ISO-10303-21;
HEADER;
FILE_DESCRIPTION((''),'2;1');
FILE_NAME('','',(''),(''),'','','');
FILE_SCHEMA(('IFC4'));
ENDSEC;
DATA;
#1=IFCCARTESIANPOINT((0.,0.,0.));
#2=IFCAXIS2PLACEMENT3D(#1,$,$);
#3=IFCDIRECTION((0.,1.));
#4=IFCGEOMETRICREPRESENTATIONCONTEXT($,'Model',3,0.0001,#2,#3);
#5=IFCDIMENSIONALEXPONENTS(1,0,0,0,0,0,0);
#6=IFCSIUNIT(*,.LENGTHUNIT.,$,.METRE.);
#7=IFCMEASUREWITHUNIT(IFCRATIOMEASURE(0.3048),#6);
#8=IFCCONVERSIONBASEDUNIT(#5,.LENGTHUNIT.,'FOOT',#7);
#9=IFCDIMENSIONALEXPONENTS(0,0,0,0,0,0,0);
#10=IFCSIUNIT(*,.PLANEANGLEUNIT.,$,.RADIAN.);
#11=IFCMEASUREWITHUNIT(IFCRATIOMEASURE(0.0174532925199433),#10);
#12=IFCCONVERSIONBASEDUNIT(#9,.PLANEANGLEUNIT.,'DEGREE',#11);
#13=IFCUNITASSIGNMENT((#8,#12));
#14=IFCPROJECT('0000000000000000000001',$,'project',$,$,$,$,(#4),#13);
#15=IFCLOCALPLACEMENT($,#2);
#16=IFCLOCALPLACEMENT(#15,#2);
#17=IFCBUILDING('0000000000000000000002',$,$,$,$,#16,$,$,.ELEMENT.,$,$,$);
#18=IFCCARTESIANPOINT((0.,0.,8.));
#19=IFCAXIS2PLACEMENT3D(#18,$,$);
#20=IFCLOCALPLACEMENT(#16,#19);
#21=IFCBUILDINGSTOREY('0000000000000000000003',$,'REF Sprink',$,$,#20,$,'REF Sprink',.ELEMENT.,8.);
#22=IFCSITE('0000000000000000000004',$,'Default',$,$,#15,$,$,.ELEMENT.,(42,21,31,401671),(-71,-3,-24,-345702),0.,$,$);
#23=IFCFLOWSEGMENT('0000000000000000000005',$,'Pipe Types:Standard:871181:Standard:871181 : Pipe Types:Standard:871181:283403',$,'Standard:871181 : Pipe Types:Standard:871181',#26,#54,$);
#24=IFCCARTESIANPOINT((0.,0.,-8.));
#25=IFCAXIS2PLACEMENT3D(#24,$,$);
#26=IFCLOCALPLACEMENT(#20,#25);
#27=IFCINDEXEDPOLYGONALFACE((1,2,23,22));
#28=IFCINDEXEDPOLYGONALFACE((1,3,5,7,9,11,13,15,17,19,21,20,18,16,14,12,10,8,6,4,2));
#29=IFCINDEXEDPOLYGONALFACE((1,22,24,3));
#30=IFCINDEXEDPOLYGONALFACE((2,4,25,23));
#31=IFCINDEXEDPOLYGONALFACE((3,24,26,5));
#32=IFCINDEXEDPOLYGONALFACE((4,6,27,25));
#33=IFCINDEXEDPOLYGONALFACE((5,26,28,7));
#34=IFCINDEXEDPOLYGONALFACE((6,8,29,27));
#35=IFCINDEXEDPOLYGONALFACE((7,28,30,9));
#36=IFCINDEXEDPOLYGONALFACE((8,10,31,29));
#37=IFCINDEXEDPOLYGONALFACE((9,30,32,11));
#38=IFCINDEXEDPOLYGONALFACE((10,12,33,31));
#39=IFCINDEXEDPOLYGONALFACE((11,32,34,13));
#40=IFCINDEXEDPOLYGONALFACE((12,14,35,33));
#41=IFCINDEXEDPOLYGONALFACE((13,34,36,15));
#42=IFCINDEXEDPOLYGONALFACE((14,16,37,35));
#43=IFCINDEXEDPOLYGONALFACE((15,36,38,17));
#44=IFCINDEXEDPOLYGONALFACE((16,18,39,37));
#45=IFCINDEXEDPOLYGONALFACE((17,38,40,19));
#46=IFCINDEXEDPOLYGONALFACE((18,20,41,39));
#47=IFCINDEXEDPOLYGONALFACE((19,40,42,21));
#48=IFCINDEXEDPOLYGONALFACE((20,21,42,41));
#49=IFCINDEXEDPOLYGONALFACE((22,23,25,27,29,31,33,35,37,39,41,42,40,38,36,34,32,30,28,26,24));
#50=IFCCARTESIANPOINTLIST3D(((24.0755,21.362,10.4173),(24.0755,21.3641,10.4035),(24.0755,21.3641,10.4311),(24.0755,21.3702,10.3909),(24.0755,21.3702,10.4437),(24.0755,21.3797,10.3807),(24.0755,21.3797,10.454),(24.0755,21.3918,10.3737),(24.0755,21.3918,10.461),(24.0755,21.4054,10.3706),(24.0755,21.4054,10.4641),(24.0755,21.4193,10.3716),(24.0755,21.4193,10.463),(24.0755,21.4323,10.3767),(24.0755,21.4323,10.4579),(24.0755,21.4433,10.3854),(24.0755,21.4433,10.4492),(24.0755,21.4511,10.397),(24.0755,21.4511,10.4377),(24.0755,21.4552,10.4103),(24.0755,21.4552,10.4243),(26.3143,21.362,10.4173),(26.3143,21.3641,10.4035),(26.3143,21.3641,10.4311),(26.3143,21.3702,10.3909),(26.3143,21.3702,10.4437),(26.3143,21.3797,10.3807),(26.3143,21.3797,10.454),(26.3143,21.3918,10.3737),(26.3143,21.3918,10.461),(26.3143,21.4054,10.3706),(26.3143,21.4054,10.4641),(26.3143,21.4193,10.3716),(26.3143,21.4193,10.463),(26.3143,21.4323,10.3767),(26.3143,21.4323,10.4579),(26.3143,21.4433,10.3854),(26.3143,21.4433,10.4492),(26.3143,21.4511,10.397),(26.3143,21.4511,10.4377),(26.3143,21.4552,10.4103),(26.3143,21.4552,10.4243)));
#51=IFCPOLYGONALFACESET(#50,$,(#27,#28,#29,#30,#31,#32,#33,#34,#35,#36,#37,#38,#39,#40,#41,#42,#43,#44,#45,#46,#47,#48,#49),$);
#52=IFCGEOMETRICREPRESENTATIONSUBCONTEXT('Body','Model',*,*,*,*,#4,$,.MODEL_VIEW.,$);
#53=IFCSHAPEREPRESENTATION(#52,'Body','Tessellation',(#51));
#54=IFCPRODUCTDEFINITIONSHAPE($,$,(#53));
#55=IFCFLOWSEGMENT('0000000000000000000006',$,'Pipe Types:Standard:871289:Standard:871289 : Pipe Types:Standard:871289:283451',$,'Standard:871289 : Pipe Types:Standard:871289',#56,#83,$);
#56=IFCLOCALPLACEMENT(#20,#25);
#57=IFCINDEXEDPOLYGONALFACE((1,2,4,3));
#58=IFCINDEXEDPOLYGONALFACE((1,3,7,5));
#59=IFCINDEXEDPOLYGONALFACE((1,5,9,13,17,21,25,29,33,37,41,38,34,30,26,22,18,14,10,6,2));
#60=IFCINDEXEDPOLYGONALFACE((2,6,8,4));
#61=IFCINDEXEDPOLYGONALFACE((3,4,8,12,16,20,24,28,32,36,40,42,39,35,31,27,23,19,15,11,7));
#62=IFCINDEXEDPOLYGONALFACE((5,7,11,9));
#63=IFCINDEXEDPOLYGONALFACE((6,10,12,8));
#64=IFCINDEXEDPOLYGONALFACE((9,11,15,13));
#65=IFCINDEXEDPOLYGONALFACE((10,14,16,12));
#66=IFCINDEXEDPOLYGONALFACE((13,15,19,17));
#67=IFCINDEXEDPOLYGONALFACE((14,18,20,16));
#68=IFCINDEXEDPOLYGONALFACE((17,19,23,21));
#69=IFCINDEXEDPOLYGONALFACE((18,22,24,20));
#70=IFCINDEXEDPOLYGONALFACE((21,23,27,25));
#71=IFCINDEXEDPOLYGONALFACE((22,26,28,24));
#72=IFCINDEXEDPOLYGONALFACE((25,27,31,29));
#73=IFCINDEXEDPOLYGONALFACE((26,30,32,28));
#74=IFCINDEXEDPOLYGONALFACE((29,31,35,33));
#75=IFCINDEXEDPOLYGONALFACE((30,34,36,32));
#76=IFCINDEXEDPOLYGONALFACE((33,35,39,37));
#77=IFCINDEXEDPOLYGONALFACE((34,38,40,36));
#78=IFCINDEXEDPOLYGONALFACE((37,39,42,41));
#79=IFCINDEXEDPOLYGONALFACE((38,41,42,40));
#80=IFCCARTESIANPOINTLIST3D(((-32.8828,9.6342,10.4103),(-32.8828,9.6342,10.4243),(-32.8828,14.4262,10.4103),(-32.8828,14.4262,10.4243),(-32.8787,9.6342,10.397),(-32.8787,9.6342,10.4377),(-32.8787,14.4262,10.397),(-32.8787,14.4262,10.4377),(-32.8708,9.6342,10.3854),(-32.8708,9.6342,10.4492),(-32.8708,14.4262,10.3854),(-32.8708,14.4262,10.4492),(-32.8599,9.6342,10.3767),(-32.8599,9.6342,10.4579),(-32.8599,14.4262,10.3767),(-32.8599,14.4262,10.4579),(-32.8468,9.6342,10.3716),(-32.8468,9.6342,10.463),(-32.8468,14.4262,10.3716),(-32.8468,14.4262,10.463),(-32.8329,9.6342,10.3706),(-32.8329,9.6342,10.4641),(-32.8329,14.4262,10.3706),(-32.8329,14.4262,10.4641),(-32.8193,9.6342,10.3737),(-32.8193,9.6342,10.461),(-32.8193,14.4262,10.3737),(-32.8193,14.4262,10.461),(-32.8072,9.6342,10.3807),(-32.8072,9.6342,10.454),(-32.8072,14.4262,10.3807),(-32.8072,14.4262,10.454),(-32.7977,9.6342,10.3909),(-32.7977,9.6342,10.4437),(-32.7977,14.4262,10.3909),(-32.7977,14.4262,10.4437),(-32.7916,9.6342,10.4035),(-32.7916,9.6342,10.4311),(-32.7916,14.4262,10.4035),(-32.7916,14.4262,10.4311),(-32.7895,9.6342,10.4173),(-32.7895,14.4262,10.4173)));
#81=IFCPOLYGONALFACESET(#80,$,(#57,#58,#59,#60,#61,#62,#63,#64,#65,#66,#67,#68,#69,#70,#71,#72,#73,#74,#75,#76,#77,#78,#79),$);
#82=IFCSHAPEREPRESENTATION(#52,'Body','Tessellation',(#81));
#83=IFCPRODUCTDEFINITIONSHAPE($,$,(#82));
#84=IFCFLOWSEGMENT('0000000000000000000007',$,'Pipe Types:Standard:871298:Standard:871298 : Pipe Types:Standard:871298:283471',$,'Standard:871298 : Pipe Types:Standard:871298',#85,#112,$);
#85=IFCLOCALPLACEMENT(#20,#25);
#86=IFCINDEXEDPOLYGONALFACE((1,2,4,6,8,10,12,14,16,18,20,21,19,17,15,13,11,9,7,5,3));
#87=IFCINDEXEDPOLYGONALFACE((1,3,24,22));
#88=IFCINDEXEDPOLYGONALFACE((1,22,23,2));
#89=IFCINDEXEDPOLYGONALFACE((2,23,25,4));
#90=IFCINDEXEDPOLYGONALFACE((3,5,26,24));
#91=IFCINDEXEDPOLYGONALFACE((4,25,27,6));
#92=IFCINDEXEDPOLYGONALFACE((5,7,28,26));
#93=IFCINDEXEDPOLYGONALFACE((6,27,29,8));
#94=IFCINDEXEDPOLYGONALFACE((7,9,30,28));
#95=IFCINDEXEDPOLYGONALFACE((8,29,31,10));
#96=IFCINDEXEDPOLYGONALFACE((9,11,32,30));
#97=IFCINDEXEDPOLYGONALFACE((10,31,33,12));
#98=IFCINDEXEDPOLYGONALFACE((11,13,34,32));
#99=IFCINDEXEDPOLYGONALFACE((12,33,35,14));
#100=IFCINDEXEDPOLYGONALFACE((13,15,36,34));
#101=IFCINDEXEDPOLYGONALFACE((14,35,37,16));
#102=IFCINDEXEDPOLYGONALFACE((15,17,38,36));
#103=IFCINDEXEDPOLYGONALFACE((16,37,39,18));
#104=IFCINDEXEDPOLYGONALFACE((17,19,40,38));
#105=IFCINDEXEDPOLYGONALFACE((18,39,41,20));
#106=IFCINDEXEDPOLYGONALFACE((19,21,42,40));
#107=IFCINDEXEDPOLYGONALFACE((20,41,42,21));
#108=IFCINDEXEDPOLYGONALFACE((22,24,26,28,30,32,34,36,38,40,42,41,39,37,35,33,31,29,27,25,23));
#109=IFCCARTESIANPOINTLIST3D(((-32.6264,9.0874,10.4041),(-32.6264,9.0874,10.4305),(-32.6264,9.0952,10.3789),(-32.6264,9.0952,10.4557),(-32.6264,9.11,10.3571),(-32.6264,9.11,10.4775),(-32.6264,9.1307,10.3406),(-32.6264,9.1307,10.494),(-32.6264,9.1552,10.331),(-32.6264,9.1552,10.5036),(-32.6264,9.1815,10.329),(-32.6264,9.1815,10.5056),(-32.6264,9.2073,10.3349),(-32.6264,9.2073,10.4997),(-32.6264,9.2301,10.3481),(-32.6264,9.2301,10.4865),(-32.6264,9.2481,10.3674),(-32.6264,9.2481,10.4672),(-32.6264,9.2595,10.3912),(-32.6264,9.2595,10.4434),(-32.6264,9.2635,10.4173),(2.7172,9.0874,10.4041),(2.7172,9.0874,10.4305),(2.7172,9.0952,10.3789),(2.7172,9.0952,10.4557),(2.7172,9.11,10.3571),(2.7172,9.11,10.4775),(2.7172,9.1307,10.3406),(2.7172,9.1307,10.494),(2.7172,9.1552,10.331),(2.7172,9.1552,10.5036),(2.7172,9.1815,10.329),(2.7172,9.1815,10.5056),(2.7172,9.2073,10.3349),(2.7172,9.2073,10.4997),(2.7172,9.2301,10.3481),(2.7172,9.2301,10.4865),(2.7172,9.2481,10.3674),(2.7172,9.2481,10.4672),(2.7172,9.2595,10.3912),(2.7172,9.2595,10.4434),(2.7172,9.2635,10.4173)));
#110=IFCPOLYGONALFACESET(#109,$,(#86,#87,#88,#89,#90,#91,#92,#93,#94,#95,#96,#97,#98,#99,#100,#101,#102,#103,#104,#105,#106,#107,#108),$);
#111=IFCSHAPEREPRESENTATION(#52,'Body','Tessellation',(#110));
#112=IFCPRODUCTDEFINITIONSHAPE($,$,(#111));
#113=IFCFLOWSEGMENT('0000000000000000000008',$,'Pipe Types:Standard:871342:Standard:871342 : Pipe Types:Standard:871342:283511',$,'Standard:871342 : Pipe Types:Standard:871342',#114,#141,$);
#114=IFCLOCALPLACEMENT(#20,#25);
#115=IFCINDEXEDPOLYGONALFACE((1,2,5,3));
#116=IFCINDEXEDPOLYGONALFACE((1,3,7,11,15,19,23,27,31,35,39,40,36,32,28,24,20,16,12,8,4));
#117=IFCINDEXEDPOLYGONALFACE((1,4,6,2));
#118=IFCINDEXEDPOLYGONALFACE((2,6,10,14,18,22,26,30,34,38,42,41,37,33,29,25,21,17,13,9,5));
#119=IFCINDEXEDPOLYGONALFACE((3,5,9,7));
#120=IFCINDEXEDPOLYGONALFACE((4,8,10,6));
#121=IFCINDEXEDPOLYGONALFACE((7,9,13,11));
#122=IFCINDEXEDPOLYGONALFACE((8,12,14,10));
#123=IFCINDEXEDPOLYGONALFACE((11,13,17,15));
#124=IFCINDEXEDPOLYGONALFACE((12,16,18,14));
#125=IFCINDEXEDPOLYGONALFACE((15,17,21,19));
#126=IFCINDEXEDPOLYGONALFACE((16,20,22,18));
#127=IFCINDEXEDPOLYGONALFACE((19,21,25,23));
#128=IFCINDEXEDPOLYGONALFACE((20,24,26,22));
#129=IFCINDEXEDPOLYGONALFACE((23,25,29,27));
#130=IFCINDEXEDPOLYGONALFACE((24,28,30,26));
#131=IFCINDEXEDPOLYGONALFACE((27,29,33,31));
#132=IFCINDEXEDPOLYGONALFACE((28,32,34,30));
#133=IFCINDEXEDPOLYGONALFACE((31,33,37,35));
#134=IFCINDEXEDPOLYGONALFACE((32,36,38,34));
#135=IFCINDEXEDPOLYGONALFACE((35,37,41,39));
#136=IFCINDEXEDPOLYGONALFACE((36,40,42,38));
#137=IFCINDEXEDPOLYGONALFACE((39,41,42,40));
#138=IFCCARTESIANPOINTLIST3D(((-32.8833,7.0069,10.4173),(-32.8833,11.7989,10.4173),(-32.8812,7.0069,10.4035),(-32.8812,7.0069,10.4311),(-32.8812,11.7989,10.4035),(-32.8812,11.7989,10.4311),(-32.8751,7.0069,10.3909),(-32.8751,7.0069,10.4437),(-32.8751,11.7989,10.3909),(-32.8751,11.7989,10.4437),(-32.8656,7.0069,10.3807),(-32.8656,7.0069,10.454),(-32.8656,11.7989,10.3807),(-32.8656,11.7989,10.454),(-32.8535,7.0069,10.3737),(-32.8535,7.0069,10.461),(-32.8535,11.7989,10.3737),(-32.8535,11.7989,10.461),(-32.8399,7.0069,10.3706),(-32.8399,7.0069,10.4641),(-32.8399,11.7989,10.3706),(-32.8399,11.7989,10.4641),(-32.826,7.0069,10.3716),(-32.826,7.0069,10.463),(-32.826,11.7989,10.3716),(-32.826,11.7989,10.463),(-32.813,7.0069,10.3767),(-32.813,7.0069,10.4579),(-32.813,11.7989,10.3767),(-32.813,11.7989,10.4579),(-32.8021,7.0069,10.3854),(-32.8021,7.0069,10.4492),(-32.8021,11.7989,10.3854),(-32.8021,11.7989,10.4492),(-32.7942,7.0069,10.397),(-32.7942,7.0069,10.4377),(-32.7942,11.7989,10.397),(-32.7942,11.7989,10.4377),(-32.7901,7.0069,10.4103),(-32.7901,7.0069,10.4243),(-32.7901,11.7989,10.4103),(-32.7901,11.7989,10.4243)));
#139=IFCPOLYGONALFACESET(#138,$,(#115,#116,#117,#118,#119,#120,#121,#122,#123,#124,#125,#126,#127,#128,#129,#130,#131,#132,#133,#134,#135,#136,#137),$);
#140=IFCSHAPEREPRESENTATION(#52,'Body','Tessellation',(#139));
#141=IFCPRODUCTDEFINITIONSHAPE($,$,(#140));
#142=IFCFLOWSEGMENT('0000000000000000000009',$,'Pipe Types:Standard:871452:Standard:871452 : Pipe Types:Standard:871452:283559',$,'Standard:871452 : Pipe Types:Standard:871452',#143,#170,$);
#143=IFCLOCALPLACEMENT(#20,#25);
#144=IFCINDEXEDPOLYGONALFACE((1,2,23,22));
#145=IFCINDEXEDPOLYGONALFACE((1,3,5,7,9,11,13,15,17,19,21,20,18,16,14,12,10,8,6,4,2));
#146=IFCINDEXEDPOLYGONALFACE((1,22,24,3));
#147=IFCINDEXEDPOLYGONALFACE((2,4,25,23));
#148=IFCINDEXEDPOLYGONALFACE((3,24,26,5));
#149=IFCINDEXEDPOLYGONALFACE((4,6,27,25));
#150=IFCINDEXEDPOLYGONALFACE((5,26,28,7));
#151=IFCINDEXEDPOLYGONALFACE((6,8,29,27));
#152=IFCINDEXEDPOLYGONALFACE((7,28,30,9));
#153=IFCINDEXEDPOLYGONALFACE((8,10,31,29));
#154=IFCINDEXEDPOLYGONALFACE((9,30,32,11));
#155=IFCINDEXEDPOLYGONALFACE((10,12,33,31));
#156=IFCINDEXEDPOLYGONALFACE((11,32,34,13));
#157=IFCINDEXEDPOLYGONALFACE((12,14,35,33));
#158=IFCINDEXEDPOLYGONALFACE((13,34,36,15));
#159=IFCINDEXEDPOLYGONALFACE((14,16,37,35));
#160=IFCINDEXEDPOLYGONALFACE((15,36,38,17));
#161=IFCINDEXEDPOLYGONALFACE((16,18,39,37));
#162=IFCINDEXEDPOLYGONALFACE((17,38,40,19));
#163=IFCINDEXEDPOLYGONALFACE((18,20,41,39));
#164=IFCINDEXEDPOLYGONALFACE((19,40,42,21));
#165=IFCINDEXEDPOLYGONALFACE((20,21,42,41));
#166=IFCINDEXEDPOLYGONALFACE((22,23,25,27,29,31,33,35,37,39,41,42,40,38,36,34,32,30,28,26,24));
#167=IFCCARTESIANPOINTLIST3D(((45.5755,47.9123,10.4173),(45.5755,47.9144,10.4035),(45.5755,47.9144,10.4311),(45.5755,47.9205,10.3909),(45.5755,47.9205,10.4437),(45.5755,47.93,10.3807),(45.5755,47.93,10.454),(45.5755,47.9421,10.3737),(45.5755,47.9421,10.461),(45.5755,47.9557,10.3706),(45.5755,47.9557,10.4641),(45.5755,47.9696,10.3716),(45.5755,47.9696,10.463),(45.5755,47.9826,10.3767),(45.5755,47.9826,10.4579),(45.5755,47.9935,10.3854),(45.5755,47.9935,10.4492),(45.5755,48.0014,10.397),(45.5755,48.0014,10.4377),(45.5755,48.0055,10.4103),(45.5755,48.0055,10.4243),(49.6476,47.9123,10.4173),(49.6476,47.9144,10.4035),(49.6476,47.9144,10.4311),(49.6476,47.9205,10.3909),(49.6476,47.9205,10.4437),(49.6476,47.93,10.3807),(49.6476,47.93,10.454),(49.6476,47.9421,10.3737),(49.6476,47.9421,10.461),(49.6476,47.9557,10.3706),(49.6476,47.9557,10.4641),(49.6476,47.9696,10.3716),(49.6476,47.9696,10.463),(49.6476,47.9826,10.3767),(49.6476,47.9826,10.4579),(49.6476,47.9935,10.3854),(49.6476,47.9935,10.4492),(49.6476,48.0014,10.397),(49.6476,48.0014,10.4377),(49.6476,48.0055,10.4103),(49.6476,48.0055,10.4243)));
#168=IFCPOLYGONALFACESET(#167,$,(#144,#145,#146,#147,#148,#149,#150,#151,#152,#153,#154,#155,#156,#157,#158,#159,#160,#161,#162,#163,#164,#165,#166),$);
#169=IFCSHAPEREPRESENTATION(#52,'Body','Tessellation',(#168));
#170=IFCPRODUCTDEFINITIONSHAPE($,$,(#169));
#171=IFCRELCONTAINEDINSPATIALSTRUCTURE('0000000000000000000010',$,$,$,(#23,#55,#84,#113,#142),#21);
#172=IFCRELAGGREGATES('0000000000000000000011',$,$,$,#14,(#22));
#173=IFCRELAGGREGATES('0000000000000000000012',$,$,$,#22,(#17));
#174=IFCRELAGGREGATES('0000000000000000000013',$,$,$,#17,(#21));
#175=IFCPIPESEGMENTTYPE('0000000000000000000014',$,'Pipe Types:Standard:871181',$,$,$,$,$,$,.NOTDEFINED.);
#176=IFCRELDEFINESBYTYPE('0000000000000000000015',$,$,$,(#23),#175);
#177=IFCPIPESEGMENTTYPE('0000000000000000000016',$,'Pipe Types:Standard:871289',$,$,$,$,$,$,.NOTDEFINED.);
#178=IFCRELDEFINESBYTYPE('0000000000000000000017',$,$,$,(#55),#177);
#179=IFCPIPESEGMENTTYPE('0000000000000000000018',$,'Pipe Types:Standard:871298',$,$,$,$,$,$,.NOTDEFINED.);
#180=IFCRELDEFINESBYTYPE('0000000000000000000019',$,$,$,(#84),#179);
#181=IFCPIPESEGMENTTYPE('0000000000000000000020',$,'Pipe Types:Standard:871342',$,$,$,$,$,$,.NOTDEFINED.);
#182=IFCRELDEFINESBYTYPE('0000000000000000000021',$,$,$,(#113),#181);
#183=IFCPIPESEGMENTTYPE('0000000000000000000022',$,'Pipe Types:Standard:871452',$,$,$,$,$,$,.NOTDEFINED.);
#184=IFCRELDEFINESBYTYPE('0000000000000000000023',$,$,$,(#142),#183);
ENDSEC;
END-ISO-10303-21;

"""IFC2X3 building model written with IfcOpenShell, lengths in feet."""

from ifc_helpers import new_model, entity, si_unit, converted_unit, direction, frame, origin, origin_2d_with_axis, place, context, subcontext, project, spatial, circle, extrude, source, transform, mapped, type_object, type_shapes, element, save


model = new_model("IFC2X3")

# Units and contexts
model_context = context("Model", 3, precision=0.0001, world=origin(), true_north=direction((0.0, 1.0)))
body_context = subcontext(model_context, "Body", "Model", "MODEL_VIEW")
ifc_project = project(units=[converted_unit("LENGTHUNIT", "FOOT", entity("IfcRatioMeasure", 0.3048), si_unit("LENGTHUNIT", "METRE"), dimensions=[1, 0, 0, 0, 0, 0, 0]), converted_unit("PLANEANGLEUNIT", "DEGREE", entity("IfcRatioMeasure", 0.0174532925199433), si_unit("PLANEANGLEUNIT", "RADIAN"), dimensions=[0, 0, 0, 0, 0, 0, 0])], contexts=[model_context])

# Site, building, storey
site_placement = place(None, origin())
site = spatial("IfcSite", under=ifc_project, at=site_placement, Name="Default", CompositionType="ELEMENT", RefLatitude=(42, 21, 31, 401671), RefLongitude=(-71, -3, -24, -345702), RefElevation=0.0)
building_placement = place(site_placement, origin())
building = spatial("IfcBuilding", under=site, at=building_placement, CompositionType="ELEMENT")
storey_placement = place(building_placement, frame((0.0, 0.0, 8.0)))
storey = spatial("IfcBuildingStorey", under=building, at=storey_placement, Name="REF Sprink", LongName="REF Sprink", CompositionType="ELEMENT", Elevation=8.0)

# Flow segments
pipe_segment_type_1 = type_object("IfcPipeSegmentType", Name="Pipe Types:Standard:871181", PredefinedType="NOTDEFINED")
shared_shape_1 = source(origin(), body_context, "Body", "SweptSolid", [
    extrude(circle(Radius=0.0469, at=origin_2d_with_axis()), frame((24.0755, 21.4089, 10.4173), z_axis=(1.0, 0.0, 0.0), x_axis=(0.0, -1.0, 0.0)), (0.0, 0.0, 1.0), 2.2388),
])
type_shapes(pipe_segment_type_1, [shared_shape_1])
flow_segment_1_placement = place(storey_placement, frame((0.0, 0.0, -8.0)))
element("IfcFlowSegment", 1, at=flow_segment_1_placement, inside=storey, type_object=pipe_segment_type_1, Name="Pipe Types:Standard:871181:Standard:871181 : Pipe Types:Standard:871181:283403", ObjectType="Standard:871181 : Pipe Types:Standard:871181", context=body_context, shape_type="MappedRepresentation", body=[
    mapped(shared_shape_1, transform((0.0, 0.0, 0.0), scale=1.0)),
])
pipe_segment_type_2 = type_object("IfcPipeSegmentType", Name="Pipe Types:Standard:871289", PredefinedType="NOTDEFINED")
shared_shape_2 = source(origin(), body_context, "Body", "SweptSolid", [
    extrude(circle(Radius=0.0469, at=origin_2d_with_axis()), frame((-32.8364, 9.6342, 10.4173), z_axis=(0.0, 1.0, 0.0), x_axis=(1.0, 0.0, 0.0)), (0.0, 0.0, 1.0), 4.792),
])
type_shapes(pipe_segment_type_2, [shared_shape_2])
flow_segment_2_placement = place(storey_placement, frame((0.0, 0.0, -8.0)))
element("IfcFlowSegment", 2, at=flow_segment_2_placement, inside=storey, type_object=pipe_segment_type_2, Name="Pipe Types:Standard:871289:Standard:871289 : Pipe Types:Standard:871289:283451", ObjectType="Standard:871289 : Pipe Types:Standard:871289", context=body_context, shape_type="MappedRepresentation", body=[
    mapped(shared_shape_2, transform((0.0, 0.0, 0.0), scale=1.0)),
])
pipe_segment_type_3 = type_object("IfcPipeSegmentType", Name="Pipe Types:Standard:871298", PredefinedType="NOTDEFINED")
shared_shape_3 = source(origin(), body_context, "Body", "SweptSolid", [
    extrude(circle(Radius=0.0885, at=origin_2d_with_axis()), frame((-32.6264, 9.1749, 10.4173), z_axis=(1.0, 0.0, 0.0), x_axis=(0.0, 1.0, 0.0)), (0.0, 0.0, 1.0), 35.3436),
])
type_shapes(pipe_segment_type_3, [shared_shape_3])
flow_segment_3_placement = place(storey_placement, frame((0.0, 0.0, -8.0)))
element("IfcFlowSegment", 3, at=flow_segment_3_placement, inside=storey, type_object=pipe_segment_type_3, Name="Pipe Types:Standard:871298:Standard:871298 : Pipe Types:Standard:871298:283471", ObjectType="Standard:871298 : Pipe Types:Standard:871298", context=body_context, shape_type="MappedRepresentation", body=[
    mapped(shared_shape_3, transform((0.0, 0.0, 0.0), scale=1.0)),
])
pipe_segment_type_4 = type_object("IfcPipeSegmentType", Name="Pipe Types:Standard:871342", PredefinedType="NOTDEFINED")
shared_shape_4 = source(origin(), body_context, "Body", "SweptSolid", [
    extrude(circle(Radius=0.0469, at=origin_2d_with_axis()), frame((-32.8364, 7.0069, 10.4173), z_axis=(0.0, 1.0, 0.0), x_axis=(-1.0, 0.0, 0.0)), (0.0, 0.0, 1.0), 4.792),
])
type_shapes(pipe_segment_type_4, [shared_shape_4])
flow_segment_4_placement = place(storey_placement, frame((0.0, 0.0, -8.0)))
element("IfcFlowSegment", 4, at=flow_segment_4_placement, inside=storey, type_object=pipe_segment_type_4, Name="Pipe Types:Standard:871342:Standard:871342 : Pipe Types:Standard:871342:283511", ObjectType="Standard:871342 : Pipe Types:Standard:871342", context=body_context, shape_type="MappedRepresentation", body=[
    mapped(shared_shape_4, transform((0.0, 0.0, 0.0), scale=1.0)),
])
pipe_segment_type_5 = type_object("IfcPipeSegmentType", Name="Pipe Types:Standard:871452", PredefinedType="NOTDEFINED")
shared_shape_5 = source(origin(), body_context, "Body", "SweptSolid", [
    extrude(circle(Radius=0.0469, at=origin_2d_with_axis()), frame((45.5755, 47.9592, 10.4173), z_axis=(1.0, 0.0, 0.0), x_axis=(0.0, -1.0, 0.0)), (0.0, 0.0, 1.0), 4.0722),
])
type_shapes(pipe_segment_type_5, [shared_shape_5])
flow_segment_5_placement = place(storey_placement, frame((0.0, 0.0, -8.0)))
element("IfcFlowSegment", 5, at=flow_segment_5_placement, inside=storey, type_object=pipe_segment_type_5, Name="Pipe Types:Standard:871452:Standard:871452 : Pipe Types:Standard:871452:283559", ObjectType="Standard:871452 : Pipe Types:Standard:871452", context=body_context, shape_type="MappedRepresentation", body=[
    mapped(shared_shape_5, transform((0.0, 0.0, 0.0), scale=1.0)),
])

save(model, "model.ifc")
